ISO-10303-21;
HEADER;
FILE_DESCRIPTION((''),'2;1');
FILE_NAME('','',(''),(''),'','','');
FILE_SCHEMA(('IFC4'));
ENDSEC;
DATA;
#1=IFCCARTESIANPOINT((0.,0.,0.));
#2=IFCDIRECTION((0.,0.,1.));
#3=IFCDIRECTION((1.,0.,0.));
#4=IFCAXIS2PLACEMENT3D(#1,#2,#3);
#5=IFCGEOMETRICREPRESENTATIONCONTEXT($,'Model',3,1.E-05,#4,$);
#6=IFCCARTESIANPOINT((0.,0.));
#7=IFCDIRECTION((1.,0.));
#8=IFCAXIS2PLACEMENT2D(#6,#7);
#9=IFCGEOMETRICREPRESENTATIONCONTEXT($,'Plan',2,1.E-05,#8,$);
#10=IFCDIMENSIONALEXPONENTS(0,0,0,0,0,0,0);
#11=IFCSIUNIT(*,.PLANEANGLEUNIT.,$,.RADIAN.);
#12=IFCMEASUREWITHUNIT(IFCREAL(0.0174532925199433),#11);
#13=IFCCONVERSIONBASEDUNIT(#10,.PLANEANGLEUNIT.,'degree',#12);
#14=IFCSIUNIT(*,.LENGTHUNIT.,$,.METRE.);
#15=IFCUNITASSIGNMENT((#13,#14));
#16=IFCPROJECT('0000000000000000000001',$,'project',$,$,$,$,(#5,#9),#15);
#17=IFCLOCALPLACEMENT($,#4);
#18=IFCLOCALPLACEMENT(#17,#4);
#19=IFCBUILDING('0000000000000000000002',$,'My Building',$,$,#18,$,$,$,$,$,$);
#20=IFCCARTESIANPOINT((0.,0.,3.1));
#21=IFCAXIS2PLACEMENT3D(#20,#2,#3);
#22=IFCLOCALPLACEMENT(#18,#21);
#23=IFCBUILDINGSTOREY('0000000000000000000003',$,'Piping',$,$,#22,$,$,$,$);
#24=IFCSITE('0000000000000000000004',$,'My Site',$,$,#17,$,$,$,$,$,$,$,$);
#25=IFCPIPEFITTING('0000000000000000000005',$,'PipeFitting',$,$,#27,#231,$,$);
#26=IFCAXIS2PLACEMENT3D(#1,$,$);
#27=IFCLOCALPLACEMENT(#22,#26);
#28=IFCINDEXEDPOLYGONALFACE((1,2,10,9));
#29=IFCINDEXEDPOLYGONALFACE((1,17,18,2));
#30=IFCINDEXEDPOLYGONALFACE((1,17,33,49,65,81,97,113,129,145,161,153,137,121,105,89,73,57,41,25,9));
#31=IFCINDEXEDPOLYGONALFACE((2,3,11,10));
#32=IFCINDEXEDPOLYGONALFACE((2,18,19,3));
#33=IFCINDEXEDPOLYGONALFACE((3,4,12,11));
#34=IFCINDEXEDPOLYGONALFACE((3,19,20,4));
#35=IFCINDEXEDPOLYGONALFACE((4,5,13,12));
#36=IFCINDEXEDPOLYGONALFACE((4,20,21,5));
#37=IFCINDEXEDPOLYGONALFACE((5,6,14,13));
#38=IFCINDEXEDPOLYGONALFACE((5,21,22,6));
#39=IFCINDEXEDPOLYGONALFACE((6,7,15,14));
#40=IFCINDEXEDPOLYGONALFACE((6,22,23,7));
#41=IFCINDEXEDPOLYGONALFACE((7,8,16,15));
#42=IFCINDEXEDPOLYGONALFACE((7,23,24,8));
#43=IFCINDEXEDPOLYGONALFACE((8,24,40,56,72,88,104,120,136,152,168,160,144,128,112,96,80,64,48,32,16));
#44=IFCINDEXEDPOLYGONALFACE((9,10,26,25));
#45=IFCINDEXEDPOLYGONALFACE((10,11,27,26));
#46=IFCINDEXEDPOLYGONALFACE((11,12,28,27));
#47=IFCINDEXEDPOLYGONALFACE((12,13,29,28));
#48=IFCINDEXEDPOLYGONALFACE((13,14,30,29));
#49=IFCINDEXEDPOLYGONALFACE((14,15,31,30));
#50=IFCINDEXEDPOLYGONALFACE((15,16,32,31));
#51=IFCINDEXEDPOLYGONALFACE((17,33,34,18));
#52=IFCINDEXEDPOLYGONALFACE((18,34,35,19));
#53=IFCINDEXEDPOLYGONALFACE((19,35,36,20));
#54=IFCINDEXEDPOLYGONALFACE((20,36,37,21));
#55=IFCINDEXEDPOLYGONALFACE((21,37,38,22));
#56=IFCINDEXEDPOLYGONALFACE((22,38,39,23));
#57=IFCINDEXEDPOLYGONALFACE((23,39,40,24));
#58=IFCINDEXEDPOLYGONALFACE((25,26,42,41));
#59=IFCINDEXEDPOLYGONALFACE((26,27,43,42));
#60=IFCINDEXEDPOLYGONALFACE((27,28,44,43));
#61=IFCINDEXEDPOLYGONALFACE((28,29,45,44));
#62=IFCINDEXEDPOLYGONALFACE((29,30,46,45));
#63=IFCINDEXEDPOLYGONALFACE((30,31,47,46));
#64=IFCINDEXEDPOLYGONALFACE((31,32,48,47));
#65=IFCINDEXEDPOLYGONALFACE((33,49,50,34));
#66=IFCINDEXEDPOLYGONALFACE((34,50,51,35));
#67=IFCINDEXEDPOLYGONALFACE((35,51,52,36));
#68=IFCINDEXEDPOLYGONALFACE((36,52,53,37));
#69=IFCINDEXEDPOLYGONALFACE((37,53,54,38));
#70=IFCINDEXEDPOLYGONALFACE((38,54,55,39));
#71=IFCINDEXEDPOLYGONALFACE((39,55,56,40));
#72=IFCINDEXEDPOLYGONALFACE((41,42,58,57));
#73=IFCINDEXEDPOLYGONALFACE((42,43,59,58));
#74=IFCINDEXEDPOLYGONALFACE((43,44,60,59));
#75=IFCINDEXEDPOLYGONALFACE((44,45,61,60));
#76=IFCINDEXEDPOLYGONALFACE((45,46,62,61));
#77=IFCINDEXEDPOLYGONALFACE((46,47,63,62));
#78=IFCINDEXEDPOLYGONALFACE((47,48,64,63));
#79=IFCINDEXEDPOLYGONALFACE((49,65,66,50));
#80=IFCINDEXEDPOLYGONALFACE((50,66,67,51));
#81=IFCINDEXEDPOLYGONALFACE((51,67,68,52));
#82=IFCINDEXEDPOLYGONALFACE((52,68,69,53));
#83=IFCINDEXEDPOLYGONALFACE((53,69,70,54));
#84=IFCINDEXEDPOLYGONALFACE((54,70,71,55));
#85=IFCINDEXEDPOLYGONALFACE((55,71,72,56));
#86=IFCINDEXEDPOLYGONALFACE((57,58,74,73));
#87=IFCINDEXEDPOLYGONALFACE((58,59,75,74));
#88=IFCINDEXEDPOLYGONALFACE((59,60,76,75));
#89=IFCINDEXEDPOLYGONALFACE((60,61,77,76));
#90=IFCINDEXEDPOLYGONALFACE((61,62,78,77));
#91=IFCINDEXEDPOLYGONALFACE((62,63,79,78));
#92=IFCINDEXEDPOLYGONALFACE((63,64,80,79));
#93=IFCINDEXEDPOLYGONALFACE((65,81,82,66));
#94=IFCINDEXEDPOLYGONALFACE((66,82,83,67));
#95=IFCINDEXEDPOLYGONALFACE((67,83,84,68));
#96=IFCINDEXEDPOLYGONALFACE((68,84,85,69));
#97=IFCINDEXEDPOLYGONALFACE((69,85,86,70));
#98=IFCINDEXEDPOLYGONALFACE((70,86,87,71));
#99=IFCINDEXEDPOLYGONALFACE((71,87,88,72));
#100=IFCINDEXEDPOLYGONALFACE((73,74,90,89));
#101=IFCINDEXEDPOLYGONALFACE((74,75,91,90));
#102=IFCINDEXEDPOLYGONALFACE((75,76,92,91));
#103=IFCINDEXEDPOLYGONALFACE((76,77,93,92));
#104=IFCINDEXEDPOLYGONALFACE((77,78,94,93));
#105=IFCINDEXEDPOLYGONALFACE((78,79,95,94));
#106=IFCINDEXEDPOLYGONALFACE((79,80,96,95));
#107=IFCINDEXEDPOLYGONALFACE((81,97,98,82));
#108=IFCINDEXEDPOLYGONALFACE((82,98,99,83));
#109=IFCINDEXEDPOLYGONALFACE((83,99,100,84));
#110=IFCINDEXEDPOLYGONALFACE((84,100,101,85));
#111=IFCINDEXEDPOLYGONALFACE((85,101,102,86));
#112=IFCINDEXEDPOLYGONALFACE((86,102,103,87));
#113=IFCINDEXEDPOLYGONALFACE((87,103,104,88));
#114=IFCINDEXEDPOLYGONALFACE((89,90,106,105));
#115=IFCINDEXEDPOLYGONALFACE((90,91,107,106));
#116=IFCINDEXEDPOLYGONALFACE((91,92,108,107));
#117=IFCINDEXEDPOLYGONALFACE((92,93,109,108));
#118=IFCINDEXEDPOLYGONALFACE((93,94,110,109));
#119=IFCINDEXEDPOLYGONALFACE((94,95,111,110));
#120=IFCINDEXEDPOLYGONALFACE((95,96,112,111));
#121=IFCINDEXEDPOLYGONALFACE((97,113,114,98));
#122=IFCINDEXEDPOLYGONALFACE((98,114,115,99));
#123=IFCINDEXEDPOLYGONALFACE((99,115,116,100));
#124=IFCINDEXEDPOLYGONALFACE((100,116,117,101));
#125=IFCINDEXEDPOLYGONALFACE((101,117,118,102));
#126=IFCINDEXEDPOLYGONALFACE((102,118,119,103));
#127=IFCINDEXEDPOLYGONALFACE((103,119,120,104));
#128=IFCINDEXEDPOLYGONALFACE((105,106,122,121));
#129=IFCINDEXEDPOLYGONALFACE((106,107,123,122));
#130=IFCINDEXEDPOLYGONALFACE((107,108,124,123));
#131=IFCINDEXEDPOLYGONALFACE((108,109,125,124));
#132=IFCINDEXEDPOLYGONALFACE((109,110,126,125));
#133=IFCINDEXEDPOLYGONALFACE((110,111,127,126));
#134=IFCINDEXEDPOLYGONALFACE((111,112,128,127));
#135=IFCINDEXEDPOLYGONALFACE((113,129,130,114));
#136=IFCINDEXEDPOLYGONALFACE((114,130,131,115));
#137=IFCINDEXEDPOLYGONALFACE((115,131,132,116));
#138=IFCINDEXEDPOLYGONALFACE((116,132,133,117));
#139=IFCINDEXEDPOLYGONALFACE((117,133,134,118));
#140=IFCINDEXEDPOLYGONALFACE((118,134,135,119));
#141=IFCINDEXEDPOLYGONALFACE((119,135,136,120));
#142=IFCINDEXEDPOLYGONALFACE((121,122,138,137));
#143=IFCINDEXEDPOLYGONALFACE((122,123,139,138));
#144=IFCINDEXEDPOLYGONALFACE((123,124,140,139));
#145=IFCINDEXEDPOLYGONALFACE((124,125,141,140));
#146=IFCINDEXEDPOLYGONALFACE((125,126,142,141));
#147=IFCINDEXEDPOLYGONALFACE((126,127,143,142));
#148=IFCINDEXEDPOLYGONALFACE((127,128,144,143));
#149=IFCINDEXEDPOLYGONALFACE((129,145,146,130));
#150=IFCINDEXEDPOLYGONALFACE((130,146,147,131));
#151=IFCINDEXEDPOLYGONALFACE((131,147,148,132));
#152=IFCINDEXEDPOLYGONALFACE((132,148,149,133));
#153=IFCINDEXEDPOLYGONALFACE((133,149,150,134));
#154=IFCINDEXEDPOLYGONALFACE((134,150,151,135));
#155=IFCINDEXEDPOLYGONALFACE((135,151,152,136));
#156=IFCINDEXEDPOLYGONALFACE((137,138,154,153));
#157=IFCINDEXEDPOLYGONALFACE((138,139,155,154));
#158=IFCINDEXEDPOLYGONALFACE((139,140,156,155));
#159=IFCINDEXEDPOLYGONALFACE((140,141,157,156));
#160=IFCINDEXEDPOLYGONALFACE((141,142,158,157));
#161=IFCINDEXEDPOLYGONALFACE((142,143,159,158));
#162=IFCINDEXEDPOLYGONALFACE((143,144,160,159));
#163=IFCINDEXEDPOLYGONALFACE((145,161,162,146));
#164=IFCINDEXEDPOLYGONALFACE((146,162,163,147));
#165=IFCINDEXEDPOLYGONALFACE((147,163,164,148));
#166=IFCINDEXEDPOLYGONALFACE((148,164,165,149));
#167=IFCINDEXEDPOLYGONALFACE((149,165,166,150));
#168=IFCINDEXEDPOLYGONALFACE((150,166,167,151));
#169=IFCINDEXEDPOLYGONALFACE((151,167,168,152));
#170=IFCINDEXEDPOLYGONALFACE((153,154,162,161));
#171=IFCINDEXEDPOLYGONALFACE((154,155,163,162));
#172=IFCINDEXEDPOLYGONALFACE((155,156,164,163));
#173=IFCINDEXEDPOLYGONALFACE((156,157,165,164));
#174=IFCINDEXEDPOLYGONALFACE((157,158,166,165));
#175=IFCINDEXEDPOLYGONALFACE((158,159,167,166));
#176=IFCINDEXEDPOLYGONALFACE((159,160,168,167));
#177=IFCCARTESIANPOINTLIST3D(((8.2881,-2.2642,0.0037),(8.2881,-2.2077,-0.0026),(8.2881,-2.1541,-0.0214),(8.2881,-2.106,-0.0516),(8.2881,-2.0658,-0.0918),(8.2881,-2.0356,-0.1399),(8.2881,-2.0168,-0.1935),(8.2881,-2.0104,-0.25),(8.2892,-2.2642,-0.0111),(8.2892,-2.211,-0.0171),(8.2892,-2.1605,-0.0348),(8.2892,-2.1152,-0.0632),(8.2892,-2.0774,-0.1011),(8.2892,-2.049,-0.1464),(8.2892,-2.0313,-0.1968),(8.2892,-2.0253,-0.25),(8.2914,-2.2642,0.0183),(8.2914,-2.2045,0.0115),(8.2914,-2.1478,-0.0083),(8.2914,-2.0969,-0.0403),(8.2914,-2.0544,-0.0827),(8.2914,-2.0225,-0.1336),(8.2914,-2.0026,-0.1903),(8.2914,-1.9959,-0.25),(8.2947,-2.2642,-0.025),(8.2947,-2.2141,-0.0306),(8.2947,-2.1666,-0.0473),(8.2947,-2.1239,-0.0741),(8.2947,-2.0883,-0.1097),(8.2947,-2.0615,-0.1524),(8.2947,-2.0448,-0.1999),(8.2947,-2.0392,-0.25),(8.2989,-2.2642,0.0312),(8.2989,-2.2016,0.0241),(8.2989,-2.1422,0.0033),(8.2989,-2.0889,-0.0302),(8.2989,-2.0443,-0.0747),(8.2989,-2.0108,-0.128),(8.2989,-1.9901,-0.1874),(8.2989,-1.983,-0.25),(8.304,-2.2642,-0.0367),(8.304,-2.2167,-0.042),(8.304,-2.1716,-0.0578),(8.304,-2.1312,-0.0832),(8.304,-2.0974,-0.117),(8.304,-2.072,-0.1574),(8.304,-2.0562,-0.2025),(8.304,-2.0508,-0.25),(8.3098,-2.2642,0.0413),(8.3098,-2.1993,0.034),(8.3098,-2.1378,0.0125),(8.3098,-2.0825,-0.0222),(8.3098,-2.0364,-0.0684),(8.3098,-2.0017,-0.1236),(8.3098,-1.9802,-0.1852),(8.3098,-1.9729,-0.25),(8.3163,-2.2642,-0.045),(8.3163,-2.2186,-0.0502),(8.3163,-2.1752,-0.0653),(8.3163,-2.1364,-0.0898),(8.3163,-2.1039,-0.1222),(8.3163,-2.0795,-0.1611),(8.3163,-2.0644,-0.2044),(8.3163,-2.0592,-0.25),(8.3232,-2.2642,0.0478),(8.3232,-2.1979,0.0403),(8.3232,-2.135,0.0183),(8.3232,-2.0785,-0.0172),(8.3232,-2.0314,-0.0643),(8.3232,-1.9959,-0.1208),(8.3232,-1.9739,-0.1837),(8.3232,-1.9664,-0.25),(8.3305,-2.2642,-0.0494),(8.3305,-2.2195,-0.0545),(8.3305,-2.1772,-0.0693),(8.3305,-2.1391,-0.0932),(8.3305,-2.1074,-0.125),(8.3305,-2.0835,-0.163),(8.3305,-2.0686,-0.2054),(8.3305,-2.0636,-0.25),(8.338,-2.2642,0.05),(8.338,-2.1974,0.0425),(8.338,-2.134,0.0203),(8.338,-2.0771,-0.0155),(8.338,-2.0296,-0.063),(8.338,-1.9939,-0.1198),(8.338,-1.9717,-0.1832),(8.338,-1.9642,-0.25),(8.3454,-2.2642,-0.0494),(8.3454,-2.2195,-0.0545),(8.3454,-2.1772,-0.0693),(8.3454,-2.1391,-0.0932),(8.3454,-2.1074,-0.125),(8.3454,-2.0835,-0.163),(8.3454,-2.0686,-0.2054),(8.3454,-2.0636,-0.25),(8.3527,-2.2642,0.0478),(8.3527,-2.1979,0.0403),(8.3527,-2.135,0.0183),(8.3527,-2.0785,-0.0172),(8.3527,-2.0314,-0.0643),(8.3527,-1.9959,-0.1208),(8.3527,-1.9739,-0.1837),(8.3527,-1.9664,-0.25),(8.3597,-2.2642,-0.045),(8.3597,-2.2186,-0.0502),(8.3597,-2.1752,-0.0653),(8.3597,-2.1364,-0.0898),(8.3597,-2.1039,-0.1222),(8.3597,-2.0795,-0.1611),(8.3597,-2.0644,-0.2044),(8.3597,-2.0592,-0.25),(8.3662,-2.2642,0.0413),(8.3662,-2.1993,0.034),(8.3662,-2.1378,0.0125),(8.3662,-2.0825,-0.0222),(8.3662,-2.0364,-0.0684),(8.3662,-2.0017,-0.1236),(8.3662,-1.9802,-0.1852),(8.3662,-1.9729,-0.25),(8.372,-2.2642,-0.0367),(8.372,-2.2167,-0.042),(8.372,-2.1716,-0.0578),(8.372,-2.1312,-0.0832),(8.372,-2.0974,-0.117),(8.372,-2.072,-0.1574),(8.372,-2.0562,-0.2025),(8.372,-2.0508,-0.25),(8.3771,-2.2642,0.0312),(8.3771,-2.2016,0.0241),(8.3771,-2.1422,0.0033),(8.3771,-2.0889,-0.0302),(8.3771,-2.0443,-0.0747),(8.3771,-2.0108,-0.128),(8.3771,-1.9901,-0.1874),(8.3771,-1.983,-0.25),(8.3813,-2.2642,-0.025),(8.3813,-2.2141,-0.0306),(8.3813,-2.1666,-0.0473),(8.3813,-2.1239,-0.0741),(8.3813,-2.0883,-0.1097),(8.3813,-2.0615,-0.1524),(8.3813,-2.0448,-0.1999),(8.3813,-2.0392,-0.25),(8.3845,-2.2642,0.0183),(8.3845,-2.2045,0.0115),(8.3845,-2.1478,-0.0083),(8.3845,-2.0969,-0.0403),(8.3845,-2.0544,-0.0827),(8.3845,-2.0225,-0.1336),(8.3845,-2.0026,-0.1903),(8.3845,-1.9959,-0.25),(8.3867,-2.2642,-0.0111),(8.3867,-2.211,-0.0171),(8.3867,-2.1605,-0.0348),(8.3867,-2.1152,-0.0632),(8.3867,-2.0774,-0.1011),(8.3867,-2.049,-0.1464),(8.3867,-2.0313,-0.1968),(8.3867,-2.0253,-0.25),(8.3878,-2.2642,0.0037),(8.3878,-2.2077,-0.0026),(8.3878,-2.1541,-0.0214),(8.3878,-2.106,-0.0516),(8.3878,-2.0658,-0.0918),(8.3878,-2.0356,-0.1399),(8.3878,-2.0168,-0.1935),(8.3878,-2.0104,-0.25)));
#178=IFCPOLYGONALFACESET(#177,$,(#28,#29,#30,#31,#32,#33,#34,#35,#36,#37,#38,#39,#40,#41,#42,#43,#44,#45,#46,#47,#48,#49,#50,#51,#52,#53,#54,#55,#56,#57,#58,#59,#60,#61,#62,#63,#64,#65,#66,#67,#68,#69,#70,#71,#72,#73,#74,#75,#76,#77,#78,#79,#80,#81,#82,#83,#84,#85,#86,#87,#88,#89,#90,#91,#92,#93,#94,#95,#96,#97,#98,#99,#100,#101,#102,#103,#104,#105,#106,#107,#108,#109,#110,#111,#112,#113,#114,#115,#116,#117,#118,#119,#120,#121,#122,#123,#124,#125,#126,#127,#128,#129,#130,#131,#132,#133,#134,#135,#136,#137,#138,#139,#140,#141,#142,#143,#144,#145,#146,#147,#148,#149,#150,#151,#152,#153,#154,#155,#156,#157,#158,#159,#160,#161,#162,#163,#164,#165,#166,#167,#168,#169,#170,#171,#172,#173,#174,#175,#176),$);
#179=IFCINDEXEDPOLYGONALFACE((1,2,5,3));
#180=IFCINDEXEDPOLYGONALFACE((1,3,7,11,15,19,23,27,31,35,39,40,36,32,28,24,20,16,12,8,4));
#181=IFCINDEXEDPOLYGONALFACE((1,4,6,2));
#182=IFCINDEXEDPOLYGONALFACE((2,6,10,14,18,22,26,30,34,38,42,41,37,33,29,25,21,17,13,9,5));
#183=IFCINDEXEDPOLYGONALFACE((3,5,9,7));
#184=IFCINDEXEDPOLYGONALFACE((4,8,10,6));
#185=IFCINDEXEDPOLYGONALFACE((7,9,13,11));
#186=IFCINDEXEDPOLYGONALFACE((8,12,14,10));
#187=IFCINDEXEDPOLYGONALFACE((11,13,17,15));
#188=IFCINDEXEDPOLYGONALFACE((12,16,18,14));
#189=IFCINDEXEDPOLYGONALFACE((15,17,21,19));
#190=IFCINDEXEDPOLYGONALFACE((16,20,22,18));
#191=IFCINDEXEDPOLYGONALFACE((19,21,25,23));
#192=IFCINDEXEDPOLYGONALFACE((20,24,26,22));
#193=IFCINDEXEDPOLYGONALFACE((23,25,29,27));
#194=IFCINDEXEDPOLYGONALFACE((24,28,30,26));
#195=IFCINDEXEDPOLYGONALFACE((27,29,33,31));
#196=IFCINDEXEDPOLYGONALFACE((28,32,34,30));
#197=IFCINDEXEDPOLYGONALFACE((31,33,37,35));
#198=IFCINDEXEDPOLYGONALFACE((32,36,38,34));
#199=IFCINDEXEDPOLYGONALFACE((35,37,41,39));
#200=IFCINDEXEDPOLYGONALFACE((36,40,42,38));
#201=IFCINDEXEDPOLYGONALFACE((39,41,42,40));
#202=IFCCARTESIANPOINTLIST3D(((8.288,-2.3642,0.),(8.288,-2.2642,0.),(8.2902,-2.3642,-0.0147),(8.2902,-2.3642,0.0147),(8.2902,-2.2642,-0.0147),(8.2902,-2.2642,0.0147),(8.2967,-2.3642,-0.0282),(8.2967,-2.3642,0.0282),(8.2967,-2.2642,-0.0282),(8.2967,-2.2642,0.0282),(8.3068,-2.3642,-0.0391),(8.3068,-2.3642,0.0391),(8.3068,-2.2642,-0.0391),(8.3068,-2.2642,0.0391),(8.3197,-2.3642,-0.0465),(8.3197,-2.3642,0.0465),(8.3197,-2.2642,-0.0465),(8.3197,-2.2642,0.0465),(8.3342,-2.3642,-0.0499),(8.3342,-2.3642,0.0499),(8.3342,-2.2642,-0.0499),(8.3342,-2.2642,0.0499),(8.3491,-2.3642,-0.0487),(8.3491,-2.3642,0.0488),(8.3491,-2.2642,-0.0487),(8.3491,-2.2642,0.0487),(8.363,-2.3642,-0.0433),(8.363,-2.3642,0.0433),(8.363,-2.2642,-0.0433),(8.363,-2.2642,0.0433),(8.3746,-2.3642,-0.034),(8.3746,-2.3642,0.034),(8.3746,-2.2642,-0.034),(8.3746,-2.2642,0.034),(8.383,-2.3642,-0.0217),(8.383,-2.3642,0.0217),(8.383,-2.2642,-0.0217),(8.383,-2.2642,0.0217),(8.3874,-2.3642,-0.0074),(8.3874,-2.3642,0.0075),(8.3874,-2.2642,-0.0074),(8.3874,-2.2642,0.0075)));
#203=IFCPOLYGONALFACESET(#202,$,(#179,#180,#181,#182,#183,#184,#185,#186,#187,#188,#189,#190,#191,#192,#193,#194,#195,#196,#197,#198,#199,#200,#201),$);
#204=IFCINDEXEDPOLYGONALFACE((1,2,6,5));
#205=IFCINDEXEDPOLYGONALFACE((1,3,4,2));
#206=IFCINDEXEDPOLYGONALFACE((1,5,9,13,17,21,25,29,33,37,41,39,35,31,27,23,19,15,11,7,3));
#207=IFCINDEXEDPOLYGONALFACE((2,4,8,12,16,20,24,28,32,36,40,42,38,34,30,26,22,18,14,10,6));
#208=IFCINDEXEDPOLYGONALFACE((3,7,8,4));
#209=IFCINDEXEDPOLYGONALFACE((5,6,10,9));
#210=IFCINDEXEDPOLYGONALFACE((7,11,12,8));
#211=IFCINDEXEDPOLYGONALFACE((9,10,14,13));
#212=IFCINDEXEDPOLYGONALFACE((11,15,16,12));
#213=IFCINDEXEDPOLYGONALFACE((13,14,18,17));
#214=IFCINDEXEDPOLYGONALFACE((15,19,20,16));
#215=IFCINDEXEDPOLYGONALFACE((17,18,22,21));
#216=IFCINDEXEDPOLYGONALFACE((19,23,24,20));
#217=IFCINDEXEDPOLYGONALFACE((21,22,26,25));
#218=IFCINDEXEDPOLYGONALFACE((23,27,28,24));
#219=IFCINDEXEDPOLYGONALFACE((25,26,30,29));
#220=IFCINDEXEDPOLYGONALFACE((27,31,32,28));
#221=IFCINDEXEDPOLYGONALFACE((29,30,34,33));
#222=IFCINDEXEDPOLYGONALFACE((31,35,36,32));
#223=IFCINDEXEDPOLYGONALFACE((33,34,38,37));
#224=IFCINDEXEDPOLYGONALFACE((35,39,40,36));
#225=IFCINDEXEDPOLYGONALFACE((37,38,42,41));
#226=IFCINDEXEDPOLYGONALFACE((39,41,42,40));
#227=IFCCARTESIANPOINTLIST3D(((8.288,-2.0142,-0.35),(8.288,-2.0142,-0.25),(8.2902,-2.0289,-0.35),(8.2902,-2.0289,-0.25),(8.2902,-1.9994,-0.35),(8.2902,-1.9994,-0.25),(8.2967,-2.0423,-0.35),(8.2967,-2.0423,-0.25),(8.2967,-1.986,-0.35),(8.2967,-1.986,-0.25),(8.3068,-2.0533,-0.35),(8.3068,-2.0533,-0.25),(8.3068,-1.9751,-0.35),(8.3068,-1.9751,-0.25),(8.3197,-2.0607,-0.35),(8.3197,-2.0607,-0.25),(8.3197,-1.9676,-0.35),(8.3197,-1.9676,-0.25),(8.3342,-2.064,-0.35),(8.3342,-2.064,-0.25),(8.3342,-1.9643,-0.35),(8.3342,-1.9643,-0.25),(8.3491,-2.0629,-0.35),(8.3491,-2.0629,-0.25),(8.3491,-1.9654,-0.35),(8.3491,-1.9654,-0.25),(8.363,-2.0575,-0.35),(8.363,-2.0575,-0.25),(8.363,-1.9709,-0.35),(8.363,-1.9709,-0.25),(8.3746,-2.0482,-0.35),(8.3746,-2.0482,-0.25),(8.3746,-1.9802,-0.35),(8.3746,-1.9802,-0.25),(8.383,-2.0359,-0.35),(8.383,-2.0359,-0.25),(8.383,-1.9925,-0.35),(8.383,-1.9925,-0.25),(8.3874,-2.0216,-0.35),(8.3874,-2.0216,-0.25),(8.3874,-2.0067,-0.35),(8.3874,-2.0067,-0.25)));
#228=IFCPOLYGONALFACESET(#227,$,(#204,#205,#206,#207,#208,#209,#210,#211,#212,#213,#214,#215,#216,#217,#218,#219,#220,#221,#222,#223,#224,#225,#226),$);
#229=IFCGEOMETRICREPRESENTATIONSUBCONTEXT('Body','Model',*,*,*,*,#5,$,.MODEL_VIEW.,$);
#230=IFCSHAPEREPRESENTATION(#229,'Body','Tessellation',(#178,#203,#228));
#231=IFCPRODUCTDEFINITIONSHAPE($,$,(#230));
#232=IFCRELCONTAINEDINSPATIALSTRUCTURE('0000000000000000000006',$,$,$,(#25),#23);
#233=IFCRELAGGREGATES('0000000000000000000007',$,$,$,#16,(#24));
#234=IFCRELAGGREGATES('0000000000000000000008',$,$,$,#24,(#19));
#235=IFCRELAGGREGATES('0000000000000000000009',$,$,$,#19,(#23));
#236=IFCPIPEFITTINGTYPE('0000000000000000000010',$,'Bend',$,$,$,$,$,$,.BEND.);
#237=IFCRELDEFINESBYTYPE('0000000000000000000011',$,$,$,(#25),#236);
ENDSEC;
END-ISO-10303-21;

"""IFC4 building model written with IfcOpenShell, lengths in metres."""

from ifc_helpers import new_model, entity, si_unit, converted_unit, frame, origin_with_axes, origin_2d_with_axis, place, context, subcontext, project, spatial, circle, extrude, source, transform, mapped, type_object, type_shapes, element, save


model = new_model("IFC4")

# Units and contexts
model_context = context("Model", 3, precision=1e-05, world=origin_with_axes())
plan_context = context("Plan", 2, precision=1e-05, world=origin_2d_with_axis())
body_context = subcontext(model_context, "Body", "Model", "MODEL_VIEW")
ifc_project = project(units=[converted_unit("PLANEANGLEUNIT", "degree", entity("IfcReal", 0.0174532925199433), si_unit("PLANEANGLEUNIT", "RADIAN"), dimensions=[0, 0, 0, 0, 0, 0, 0]), si_unit("LENGTHUNIT", "METRE")], contexts=[model_context, plan_context])

# Site, building, storey
site_placement = place(None, origin_with_axes())
site = spatial("IfcSite", under=ifc_project, at=site_placement, Name="My Site")
building_placement = place(site_placement, origin_with_axes())
building = spatial("IfcBuilding", under=site, at=building_placement, Name="My Building")
storey_placement = place(building_placement, frame((0.0, 0.0, 3.1), z_axis=(0.0, 0.0, 1.0), x_axis=(1.0, 0.0, 0.0)))
storey = spatial("IfcBuildingStorey", under=building, at=storey_placement, Name="Piping")

# Pipe fitting
pipe_fitting_type_1 = type_object("IfcPipeFittingType", Name="Bend", PredefinedType="BEND")
shared_shape_1 = source(origin_with_axes(), body_context, "Body", "SolidModel", [
    entity("IfcSweptDiskSolid", entity("IfcIndexedPolyCurve", entity("IfcCartesianPointList3D", [[0.0, 0.0, 0.1], [0.0, -0.0732, 0.2768], [0.0, -0.25, 0.35]]), [entity("IfcArcIndex", [1, 2, 3])]), 0.05),
    extrude(circle(Radius=0.05), origin_with_axes(), (0.0, 0.0, 1.0), 0.1),
    extrude(circle(Radius=0.05), frame((0.0, -0.25, 0.35), z_axis=(0.0, -1.0, 0.000022), x_axis=(1.0, 0.0, 0.0)), (0.0, 0.0, 1.0), 0.1),
])
type_shapes(pipe_fitting_type_1, [shared_shape_1])
for number, where, z_axis, x_axis, name in (
    (1, (8.338, -2.3642, 0.0), (0.0, 1.0, -0.000022), (-1.0, 0.0, 0.0), "PipeFitting"),
):
    element("IfcPipeFitting", number, at=place(storey_placement, frame(where, z_axis=z_axis, x_axis=x_axis)), inside=storey, type_object=pipe_fitting_type_1, Name=name, context=body_context, shape_type="MappedRepresentation", body=[
        mapped(shared_shape_1, transform((0.0, 0.0, 0.0), x_axis=(1.0, 0.0, 0.0), y_axis=(0.0, 1.0, 0.0), z_axis=(0.0, 0.0, 1.0), scale=1.0)),
    ])

save(model, "model.ifc")
